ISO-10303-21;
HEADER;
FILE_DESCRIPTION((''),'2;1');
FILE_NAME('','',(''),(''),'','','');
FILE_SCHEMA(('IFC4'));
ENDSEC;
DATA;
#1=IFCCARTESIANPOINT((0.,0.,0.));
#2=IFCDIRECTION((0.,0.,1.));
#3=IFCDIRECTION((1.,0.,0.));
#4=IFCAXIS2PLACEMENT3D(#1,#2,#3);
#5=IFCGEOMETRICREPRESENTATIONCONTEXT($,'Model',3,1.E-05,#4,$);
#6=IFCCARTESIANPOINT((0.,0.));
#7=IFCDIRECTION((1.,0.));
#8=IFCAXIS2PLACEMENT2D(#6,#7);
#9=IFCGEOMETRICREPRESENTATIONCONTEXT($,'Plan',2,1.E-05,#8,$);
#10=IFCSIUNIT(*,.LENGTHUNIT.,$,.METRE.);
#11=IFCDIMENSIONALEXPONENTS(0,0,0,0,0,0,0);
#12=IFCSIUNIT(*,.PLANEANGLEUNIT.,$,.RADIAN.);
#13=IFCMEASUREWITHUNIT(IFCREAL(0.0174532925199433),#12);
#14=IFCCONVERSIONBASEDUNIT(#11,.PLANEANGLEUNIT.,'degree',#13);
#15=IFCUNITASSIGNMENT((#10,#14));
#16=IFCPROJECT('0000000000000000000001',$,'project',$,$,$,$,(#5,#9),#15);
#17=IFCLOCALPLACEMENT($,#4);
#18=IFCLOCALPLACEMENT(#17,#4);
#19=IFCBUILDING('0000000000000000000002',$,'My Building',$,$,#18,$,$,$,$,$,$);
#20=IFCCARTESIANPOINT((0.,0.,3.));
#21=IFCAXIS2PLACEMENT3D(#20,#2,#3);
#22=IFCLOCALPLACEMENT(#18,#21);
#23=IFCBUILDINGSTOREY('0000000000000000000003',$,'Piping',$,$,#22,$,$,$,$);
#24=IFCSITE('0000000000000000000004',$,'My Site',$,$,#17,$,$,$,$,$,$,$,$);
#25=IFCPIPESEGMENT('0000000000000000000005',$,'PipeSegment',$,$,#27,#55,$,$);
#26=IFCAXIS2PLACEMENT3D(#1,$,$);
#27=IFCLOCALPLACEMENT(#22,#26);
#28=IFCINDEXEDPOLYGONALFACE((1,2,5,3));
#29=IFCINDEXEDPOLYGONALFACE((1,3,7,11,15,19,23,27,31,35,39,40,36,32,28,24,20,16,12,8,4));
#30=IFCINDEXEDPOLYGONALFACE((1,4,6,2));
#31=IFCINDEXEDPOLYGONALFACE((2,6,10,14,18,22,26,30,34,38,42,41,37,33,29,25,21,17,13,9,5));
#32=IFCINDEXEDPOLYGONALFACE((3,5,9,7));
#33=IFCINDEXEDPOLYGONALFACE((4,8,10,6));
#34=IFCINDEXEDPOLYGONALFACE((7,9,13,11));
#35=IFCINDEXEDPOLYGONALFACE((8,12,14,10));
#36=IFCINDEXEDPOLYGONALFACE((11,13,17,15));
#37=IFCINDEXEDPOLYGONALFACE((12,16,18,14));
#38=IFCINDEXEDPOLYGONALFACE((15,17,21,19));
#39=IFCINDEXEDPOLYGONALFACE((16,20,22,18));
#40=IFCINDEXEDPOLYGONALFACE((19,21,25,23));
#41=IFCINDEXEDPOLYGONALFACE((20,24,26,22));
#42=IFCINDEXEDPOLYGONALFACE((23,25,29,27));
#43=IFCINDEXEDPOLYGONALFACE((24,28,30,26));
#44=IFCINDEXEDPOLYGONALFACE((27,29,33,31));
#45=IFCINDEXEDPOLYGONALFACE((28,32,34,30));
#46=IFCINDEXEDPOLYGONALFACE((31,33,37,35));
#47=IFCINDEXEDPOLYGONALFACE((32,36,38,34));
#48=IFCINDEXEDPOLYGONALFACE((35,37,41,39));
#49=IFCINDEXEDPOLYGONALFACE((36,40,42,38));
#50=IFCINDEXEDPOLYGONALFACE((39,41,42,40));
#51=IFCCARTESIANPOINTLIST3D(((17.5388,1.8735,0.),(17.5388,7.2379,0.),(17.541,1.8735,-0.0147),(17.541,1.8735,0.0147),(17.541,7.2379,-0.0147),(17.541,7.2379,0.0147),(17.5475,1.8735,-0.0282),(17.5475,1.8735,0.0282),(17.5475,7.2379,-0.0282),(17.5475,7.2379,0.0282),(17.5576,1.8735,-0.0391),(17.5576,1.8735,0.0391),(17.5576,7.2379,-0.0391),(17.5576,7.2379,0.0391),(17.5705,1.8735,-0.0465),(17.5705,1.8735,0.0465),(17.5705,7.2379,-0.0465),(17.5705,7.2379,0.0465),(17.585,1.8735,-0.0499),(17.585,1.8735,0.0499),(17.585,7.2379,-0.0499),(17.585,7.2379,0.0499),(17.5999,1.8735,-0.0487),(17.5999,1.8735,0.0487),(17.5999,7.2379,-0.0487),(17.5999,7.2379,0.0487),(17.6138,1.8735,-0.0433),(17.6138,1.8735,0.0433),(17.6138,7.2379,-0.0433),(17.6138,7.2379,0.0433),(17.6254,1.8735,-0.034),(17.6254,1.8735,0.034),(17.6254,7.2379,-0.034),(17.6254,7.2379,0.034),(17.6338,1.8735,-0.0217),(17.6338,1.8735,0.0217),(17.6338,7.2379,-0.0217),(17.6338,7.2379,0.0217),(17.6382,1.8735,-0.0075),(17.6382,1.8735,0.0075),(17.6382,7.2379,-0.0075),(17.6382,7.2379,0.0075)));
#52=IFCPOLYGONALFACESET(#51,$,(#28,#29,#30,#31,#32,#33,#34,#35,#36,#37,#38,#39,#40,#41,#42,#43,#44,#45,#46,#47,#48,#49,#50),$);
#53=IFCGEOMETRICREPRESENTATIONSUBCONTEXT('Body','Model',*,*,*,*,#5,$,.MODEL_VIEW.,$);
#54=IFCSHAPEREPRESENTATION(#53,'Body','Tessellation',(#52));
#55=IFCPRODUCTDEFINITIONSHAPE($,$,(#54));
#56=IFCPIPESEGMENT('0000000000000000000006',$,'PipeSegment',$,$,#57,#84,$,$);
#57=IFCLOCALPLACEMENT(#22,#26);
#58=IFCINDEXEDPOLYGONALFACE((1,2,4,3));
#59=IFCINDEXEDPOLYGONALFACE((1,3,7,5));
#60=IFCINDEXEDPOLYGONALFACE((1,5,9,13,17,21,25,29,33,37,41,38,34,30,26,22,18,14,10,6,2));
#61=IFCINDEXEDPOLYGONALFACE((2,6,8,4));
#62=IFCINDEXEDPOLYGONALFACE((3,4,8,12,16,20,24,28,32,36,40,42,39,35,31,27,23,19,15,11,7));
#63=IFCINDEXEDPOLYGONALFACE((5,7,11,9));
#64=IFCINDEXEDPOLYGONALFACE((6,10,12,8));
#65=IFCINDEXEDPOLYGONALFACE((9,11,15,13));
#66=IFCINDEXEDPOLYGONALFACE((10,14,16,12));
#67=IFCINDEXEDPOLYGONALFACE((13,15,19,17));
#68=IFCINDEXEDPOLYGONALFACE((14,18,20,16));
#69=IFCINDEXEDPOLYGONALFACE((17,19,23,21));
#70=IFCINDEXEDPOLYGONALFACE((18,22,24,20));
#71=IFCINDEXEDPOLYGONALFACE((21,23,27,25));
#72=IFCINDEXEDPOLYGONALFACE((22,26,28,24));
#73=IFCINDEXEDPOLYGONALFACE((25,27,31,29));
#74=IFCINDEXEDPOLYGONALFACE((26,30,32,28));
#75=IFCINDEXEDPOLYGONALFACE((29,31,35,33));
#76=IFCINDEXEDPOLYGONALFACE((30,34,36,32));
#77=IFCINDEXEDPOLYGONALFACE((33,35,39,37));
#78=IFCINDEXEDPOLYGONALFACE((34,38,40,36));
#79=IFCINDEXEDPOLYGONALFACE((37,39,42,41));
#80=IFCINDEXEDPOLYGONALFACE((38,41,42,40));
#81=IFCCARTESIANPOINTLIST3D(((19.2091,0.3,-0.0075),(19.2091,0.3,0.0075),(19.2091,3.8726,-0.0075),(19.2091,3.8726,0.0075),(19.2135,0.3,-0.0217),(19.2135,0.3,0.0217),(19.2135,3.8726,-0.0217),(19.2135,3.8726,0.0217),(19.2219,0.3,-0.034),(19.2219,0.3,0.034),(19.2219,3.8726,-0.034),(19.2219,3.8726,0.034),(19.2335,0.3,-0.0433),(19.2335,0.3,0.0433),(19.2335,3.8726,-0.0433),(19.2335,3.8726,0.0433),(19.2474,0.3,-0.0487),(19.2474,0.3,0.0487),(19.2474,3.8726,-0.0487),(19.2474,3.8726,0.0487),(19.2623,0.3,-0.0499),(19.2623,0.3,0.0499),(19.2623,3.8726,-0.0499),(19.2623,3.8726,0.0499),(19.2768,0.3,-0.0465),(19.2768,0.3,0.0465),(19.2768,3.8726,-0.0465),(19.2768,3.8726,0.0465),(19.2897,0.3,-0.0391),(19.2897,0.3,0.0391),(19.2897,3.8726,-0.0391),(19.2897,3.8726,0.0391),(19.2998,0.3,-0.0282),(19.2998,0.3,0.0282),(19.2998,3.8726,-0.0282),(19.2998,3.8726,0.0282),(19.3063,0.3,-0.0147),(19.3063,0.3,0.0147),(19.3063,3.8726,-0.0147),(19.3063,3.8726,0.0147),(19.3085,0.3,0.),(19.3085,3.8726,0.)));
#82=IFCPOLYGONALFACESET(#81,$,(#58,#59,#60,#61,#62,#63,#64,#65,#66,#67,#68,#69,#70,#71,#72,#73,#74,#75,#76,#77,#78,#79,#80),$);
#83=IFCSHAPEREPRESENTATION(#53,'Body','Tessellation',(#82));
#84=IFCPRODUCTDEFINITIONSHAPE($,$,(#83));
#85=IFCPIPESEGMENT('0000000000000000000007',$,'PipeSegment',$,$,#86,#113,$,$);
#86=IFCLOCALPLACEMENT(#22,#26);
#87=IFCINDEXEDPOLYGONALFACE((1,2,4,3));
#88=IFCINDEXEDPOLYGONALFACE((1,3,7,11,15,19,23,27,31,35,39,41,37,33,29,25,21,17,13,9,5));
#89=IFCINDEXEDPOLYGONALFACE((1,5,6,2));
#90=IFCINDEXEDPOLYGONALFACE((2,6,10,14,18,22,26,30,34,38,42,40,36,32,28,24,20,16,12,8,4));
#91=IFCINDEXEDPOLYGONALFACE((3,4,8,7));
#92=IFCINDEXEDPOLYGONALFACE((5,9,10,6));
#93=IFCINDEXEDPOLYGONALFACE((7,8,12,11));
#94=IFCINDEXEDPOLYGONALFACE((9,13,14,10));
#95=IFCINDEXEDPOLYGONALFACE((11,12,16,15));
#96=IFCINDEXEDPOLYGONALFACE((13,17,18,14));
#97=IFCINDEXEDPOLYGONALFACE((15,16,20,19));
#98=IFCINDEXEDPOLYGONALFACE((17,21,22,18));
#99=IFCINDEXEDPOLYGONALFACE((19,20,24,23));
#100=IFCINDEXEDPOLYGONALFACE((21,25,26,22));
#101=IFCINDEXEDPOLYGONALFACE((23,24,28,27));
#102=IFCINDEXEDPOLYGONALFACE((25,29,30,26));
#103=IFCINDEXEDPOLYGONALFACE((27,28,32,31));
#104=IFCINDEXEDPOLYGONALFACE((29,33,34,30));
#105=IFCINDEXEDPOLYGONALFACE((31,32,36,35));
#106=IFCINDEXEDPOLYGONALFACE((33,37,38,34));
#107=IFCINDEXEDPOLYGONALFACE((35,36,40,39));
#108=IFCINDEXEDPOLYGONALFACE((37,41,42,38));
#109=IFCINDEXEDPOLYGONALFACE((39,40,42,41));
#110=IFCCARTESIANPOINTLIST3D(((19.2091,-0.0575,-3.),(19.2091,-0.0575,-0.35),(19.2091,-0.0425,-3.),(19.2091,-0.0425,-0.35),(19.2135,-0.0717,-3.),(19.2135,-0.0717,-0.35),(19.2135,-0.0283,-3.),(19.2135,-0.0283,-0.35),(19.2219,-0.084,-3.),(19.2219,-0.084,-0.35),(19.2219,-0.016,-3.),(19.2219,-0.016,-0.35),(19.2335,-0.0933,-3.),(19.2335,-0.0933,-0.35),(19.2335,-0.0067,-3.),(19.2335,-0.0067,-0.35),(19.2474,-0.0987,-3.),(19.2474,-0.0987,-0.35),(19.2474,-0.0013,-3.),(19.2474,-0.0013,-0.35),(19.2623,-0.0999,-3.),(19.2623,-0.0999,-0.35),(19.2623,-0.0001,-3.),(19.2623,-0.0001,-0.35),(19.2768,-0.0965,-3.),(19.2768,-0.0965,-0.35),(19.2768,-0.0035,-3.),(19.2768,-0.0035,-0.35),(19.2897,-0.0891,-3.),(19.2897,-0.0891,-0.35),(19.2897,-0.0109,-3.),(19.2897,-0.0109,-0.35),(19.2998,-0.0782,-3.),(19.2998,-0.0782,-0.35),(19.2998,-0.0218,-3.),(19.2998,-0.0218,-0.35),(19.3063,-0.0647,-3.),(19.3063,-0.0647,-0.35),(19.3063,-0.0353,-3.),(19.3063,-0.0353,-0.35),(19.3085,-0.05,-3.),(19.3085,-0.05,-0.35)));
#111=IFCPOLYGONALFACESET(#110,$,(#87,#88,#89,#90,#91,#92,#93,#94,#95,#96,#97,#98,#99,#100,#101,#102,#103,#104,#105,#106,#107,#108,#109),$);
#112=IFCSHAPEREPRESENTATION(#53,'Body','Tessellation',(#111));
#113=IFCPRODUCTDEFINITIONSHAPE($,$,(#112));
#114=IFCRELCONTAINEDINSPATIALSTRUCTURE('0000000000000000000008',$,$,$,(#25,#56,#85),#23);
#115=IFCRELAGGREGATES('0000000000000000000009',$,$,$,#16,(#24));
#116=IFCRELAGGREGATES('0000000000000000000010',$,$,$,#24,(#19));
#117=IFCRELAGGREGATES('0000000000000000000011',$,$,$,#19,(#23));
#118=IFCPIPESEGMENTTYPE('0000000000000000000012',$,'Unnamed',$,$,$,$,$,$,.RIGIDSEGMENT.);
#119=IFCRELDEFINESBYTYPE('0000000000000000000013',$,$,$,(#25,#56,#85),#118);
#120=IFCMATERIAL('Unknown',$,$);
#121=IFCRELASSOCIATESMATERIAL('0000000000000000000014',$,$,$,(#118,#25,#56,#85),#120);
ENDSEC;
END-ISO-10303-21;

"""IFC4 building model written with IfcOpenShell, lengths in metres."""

from ifc_helpers import new_model, entity, si_unit, converted_unit, frame, origin_with_axes, origin_2d_with_axis, place, context, subcontext, project, spatial, circle, extrude, material, material_profile, profile_set, profile_usage, type_object, element, save


model = new_model("IFC4")

# Units and contexts
model_context = context("Model", 3, precision=1e-05, world=origin_with_axes())
plan_context = context("Plan", 2, precision=1e-05, world=origin_2d_with_axis())
body_context = subcontext(model_context, "Body", "Model", "MODEL_VIEW")
ifc_project = project(units=[si_unit("LENGTHUNIT", "METRE"), converted_unit("PLANEANGLEUNIT", "degree", entity("IfcReal", 0.0174532925199433), si_unit("PLANEANGLEUNIT", "RADIAN"), dimensions=[0, 0, 0, 0, 0, 0, 0])], contexts=[model_context, plan_context])

# Site, building, storey
site_placement = place(None, origin_with_axes())
site = spatial("IfcSite", under=ifc_project, at=site_placement, Name="My Site")
building_placement = place(site_placement, origin_with_axes())
building = spatial("IfcBuilding", under=site, at=building_placement, Name="My Building")
storey_placement = place(building_placement, frame((0.0, 0.0, 3.0), z_axis=(0.0, 0.0, 1.0), x_axis=(1.0, 0.0, 0.0)))
storey = spatial("IfcBuildingStorey", under=building, at=storey_placement, Name="Piping")

# Pipe segments
ifc_material = material(Name="Unknown")
ifc_material_profile = material_profile(ifc_material, circle(Radius=0.05))
ifc_profile_set = profile_set([ifc_material_profile])
pipe_segment_type = type_object("IfcPipeSegmentType", Name="Unnamed", PredefinedType="RIGIDSEGMENT", material=ifc_profile_set)
ifc_profile_usage_1 = profile_usage(ifc_profile_set, cardinal=5)
pipe_segment_1_placement = place(storey_placement, frame((17.5888, 1.8735, 0.0), z_axis=(0.0, 1.0, 0.0), x_axis=(-1.0, 0.0, 0.0)))
element("IfcPipeSegment", 1, at=pipe_segment_1_placement, inside=storey, type_object=pipe_segment_type, material=ifc_profile_usage_1, Name="PipeSegment", context=body_context, shape_type="SweptSolid", body=[
    extrude(circle(Radius=0.05), origin_with_axes(), (0.0, 0.0, 1.0), 5.3645),
])
ifc_profile_usage_2 = profile_usage(ifc_profile_set, cardinal=5)
pipe_segment_2_placement = place(storey_placement, frame((19.2585, 3.8726, 0.0), z_axis=(0.0, -1.0, 0.0), x_axis=(1.0, 0.0, 0.0)))
element("IfcPipeSegment", 2, at=pipe_segment_2_placement, inside=storey, type_object=pipe_segment_type, material=ifc_profile_usage_2, Name="PipeSegment", context=body_context, shape_type="SweptSolid", body=[
    extrude(circle(Radius=0.05), origin_with_axes(), (0.0, 0.0, 1.0), 3.5726),
])
ifc_profile_usage_3 = profile_usage(ifc_profile_set, cardinal=5)
pipe_segment_3_placement = place(storey_placement, frame((19.2585, -0.05, -0.35), z_axis=(0.0, 0.0, -1.0), x_axis=(1.0, 0.0, 0.0)))
element("IfcPipeSegment", 3, at=pipe_segment_3_placement, inside=storey, type_object=pipe_segment_type, material=ifc_profile_usage_3, Name="PipeSegment", context=body_context, shape_type="SweptSolid", body=[
    extrude(circle(Radius=0.05), origin_with_axes(), (0.0, 0.0, 1.0), 2.65),
])

save(model, "model.ifc")
